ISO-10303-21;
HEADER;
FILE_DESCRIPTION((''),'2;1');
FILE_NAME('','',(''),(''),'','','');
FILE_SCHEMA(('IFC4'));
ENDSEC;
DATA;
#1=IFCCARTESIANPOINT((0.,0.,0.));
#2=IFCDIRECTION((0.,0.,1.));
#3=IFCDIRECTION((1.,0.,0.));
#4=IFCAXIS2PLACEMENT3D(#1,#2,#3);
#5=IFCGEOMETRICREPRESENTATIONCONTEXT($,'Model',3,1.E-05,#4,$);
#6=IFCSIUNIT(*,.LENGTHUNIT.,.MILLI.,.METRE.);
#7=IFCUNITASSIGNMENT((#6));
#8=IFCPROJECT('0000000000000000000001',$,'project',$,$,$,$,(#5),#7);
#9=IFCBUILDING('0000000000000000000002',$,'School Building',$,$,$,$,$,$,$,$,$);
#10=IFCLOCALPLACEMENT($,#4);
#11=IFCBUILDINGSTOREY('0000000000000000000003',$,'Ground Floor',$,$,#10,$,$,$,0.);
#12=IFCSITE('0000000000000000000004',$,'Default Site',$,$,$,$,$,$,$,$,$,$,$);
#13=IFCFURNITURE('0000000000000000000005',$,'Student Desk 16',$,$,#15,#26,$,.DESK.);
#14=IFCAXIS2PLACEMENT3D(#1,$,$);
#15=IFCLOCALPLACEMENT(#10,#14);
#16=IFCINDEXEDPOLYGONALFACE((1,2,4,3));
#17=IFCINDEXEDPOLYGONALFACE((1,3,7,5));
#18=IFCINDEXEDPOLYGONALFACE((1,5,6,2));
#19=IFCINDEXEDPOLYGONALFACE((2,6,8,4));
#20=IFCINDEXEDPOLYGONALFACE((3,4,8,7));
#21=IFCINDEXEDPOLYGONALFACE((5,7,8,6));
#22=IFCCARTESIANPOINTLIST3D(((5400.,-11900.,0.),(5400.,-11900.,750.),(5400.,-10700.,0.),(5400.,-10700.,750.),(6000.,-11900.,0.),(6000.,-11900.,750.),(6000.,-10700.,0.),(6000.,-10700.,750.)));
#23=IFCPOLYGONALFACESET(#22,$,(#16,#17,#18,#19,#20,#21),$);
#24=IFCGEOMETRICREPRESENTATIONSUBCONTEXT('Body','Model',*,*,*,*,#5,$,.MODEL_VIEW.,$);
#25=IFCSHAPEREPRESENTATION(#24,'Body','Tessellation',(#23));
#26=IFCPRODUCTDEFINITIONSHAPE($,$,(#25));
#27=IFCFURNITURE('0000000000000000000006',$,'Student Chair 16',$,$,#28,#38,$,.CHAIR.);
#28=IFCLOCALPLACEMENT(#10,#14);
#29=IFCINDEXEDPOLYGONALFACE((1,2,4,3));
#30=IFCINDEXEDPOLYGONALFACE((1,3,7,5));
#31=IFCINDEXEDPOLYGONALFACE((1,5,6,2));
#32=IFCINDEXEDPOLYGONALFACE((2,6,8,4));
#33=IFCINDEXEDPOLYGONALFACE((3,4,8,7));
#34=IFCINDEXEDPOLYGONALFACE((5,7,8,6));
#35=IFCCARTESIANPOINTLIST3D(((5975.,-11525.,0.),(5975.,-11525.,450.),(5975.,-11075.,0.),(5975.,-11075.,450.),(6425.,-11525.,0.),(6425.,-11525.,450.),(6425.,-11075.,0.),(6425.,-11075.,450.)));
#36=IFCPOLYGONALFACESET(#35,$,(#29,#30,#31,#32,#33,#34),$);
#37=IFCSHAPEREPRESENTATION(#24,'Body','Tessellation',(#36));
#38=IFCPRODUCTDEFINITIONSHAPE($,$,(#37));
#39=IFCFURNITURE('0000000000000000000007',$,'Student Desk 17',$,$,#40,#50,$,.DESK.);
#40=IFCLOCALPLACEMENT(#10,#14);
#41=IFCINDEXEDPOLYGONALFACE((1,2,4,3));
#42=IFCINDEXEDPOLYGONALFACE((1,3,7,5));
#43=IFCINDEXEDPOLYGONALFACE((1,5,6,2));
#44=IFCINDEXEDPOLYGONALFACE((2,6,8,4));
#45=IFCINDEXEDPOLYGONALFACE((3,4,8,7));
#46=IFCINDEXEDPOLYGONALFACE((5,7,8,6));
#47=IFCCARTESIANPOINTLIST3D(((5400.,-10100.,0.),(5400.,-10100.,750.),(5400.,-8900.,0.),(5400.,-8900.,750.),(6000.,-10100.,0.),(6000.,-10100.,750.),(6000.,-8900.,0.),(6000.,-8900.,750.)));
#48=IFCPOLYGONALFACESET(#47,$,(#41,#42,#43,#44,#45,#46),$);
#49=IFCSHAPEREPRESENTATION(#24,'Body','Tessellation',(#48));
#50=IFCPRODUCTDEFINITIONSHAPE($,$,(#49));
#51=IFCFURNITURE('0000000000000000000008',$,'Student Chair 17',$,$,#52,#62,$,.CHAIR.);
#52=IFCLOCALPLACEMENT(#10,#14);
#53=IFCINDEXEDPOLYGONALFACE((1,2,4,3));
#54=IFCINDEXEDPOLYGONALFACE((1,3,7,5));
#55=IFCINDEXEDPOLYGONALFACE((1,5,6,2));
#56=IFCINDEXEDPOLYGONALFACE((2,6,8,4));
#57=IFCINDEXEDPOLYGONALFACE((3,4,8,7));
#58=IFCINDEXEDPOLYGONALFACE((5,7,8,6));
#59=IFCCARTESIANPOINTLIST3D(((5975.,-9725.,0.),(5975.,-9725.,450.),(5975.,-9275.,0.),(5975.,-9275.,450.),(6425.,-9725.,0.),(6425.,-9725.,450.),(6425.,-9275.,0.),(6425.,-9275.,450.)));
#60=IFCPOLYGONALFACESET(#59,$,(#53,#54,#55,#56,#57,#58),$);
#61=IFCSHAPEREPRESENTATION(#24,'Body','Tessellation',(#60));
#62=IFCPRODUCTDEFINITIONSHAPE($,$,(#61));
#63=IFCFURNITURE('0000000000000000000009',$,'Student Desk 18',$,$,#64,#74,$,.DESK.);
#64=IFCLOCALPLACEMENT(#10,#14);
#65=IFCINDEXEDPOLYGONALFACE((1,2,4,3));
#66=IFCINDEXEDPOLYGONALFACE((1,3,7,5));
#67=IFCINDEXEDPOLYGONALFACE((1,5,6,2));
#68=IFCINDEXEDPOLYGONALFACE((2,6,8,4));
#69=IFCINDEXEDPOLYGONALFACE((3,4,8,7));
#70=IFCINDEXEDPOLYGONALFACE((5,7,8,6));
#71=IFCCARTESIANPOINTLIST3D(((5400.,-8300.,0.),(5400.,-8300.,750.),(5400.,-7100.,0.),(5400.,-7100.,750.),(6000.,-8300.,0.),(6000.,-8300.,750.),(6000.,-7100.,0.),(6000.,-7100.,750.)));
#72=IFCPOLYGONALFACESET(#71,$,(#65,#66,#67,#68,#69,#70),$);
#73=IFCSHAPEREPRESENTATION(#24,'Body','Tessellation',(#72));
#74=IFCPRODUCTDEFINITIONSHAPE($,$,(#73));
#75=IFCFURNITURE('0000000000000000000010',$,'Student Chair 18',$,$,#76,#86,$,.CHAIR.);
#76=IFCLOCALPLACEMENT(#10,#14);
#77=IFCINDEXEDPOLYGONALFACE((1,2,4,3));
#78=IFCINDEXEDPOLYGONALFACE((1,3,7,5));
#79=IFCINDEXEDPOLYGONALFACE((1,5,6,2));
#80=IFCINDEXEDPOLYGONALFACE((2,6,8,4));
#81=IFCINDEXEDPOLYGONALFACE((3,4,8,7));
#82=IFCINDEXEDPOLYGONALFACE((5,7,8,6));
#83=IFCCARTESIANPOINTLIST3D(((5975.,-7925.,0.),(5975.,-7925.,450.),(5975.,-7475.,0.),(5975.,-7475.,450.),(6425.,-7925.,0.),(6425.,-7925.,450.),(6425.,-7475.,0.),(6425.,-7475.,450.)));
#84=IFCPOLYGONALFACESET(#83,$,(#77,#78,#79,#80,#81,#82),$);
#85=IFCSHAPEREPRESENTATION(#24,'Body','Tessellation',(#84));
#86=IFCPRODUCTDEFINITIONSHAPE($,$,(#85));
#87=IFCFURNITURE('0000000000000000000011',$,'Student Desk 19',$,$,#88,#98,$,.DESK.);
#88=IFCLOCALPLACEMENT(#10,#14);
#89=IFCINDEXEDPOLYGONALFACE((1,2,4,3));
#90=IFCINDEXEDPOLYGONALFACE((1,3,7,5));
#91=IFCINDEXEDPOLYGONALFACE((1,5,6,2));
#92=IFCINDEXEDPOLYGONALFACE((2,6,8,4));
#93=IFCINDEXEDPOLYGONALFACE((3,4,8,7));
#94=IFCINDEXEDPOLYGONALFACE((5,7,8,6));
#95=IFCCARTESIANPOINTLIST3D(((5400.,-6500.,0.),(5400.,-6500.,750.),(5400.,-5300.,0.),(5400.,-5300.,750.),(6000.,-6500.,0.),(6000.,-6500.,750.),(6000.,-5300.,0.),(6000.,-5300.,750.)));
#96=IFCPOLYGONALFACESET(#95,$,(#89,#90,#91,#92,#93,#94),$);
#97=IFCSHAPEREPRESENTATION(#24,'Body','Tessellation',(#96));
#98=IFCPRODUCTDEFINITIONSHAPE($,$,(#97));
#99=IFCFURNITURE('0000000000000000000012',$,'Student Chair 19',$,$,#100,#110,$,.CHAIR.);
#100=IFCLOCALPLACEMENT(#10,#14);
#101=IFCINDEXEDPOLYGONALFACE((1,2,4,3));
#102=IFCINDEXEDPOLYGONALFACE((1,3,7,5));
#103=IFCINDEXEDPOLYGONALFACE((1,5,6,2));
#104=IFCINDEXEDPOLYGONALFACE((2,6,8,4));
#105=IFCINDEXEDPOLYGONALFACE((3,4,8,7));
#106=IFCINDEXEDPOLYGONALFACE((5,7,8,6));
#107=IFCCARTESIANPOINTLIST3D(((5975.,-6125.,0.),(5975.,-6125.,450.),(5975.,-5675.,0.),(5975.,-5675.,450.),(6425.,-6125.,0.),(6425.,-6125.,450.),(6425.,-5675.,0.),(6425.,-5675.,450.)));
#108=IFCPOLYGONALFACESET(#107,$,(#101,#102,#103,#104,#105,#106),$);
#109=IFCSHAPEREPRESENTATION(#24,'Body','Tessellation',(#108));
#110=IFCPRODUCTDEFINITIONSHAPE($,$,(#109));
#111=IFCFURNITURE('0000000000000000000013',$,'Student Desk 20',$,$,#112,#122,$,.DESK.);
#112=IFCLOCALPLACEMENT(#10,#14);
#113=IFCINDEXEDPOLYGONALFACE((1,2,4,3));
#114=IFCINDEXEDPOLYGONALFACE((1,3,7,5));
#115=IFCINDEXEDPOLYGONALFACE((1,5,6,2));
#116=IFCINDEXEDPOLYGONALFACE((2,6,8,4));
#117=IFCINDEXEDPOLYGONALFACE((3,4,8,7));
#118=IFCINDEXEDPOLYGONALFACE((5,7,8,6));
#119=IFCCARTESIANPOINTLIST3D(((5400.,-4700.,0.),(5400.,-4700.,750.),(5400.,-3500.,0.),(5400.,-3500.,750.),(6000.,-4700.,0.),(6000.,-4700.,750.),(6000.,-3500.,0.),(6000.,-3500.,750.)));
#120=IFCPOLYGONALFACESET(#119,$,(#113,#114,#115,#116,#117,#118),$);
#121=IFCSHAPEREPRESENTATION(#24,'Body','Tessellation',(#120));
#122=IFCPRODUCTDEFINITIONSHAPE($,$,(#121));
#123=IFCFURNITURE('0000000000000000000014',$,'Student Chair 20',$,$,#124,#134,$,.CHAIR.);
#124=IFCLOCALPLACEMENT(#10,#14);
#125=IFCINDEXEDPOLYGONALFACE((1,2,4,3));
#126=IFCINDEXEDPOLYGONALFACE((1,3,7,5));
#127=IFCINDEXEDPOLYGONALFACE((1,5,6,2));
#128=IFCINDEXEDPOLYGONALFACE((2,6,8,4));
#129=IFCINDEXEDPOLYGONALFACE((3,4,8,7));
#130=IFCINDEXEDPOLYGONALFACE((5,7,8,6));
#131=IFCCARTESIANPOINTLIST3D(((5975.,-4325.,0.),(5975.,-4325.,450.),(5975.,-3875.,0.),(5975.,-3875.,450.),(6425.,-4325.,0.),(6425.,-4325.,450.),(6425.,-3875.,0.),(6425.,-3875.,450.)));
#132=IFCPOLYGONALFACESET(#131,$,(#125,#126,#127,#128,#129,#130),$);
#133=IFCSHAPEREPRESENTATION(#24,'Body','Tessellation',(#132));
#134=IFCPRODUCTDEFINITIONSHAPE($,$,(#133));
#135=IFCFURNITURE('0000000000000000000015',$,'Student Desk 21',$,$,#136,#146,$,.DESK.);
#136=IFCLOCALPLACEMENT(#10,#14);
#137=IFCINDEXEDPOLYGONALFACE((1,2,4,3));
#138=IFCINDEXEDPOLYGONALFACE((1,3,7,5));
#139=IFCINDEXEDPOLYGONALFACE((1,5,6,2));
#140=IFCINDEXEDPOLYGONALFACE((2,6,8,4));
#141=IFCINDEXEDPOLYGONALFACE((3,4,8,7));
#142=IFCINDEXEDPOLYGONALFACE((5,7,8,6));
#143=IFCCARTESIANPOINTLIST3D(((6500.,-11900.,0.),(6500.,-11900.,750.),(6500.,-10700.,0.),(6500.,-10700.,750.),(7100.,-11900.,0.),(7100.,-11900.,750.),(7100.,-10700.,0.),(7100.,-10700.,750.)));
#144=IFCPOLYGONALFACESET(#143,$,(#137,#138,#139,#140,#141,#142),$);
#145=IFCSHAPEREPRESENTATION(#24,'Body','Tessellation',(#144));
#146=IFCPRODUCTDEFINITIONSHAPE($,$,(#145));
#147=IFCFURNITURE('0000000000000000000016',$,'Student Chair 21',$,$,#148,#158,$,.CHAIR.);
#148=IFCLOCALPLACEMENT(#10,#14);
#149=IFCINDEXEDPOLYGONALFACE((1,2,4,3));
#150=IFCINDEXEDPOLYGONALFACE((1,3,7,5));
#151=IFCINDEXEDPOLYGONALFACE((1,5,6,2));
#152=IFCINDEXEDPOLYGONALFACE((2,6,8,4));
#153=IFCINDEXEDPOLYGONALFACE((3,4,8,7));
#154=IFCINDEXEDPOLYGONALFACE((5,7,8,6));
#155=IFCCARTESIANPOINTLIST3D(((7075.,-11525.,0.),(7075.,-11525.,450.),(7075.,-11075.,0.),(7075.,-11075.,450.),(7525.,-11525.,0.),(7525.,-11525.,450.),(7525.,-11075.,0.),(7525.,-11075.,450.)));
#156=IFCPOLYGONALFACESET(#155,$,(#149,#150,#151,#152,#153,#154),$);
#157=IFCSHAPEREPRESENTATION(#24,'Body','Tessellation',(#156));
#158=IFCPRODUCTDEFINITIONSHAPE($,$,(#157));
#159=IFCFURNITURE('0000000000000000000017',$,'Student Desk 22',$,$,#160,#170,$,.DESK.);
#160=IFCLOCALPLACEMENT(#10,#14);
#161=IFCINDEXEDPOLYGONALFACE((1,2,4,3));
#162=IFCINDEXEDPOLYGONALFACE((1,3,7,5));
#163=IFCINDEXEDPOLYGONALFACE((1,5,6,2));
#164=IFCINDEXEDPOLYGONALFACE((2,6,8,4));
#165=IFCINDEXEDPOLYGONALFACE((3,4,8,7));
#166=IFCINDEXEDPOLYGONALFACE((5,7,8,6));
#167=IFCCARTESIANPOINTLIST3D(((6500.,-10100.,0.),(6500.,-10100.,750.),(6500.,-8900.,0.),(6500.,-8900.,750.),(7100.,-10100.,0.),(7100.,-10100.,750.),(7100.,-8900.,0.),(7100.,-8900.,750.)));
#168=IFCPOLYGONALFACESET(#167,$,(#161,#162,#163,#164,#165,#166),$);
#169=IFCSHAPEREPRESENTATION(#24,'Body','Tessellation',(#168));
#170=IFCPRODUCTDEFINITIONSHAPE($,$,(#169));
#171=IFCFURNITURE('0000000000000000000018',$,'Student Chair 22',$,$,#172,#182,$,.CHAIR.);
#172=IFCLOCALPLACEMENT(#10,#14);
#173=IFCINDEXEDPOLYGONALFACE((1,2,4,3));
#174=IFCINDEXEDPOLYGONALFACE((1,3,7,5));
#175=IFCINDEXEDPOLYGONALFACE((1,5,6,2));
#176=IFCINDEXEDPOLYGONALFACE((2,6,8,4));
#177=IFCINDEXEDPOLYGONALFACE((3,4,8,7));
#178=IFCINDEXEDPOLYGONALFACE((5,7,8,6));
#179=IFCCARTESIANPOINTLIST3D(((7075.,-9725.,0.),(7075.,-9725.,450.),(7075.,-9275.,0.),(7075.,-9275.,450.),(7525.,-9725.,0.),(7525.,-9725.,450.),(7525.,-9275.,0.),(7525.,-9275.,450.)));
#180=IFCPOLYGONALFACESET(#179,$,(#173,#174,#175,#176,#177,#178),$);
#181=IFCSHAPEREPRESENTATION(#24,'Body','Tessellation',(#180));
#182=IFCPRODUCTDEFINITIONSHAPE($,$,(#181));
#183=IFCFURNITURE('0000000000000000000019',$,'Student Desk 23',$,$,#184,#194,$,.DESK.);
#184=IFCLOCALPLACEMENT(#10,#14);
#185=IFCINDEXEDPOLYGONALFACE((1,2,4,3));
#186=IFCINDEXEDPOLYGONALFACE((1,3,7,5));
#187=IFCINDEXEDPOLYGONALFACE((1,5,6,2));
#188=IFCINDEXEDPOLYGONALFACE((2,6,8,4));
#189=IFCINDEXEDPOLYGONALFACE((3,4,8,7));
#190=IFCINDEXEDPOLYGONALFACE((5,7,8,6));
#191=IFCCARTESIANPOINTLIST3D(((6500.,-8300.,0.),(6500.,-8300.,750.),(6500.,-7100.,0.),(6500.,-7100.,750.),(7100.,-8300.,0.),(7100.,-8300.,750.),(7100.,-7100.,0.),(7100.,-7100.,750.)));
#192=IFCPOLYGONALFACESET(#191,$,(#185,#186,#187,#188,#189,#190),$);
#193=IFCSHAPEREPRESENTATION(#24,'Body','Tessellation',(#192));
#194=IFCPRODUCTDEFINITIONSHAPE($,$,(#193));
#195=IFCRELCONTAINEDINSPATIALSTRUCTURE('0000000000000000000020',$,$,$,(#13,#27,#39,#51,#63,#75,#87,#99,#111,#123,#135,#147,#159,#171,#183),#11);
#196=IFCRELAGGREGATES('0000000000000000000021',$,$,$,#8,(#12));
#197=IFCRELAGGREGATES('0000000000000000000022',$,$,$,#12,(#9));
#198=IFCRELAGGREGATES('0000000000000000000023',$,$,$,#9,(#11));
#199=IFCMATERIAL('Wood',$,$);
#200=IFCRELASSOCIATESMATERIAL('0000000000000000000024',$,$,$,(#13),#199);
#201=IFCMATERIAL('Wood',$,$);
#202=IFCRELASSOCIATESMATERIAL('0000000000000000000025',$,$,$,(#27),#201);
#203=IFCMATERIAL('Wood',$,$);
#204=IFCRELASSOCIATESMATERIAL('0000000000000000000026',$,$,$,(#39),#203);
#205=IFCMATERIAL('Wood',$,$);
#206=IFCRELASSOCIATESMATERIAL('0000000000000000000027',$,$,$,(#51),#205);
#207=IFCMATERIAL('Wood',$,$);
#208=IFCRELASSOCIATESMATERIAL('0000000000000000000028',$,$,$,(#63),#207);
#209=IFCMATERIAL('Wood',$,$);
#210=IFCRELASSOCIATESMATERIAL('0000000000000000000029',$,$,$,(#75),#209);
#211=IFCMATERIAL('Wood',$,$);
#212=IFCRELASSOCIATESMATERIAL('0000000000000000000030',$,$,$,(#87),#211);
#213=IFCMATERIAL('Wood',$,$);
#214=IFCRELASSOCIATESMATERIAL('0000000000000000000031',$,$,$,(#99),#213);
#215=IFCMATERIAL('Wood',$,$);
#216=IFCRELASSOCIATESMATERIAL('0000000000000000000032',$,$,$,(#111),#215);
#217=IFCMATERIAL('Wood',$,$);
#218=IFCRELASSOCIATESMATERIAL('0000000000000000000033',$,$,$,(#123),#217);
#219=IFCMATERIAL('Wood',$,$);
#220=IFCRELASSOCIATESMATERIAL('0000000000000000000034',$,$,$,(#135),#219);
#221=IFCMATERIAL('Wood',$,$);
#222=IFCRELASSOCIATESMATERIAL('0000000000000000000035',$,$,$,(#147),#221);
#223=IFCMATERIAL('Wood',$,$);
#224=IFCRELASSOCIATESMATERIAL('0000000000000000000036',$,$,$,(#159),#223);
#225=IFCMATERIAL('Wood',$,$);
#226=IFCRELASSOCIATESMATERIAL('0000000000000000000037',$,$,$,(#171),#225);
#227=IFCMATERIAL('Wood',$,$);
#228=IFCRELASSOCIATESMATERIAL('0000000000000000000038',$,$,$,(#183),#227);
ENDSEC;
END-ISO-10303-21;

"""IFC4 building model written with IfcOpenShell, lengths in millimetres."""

from ifc_helpers import new_model, si_unit, frame, origin_with_axes, origin_2d, place, context, subcontext, project, spatial, rectangle, extrude, material, element, save


model = new_model("IFC4")

# Units and contexts
model_context = context("Model", 3, precision=1e-05, world=origin_with_axes())
body_context = subcontext(model_context, "Body", "Model", "MODEL_VIEW")
ifc_project = project(units=[si_unit("LENGTHUNIT", "METRE", prefix="MILLI")], contexts=[model_context])

# Site, building, storey
site = spatial("IfcSite", under=ifc_project, Name="Default Site")
building = spatial("IfcBuilding", under=site, Name="School Building")
storey_placement = place(None, origin_with_axes())
storey = spatial("IfcBuildingStorey", under=building, at=storey_placement, Name="Ground Floor", Elevation=0.0)

# Furniture
ifc_material_1 = material(Name="Wood")
furniture_1_placement = place(storey_placement, frame((5700.0, -11300.0, 0.0), z_axis=(0.0, 0.0, 1.0), x_axis=(0.0, 1.0, 0.0)))
element("IfcFurniture", 1, at=furniture_1_placement, inside=storey, material=ifc_material_1, Name="Student Desk 16", PredefinedType="DESK", context=body_context, shape_type="SweptSolid", body=[
    extrude(rectangle(XDim=1200.0, YDim=600.0, at=origin_2d()), origin_with_axes(), (0.0, 0.0, 1.0), 750.0),
])
ifc_material_2 = material(Name="Wood")
furniture_2_placement = place(storey_placement, frame((6200.0, -11300.0, 0.0), z_axis=(0.0, 0.0, 1.0), x_axis=(1.0, 0.0, 0.0)))
element("IfcFurniture", 2, at=furniture_2_placement, inside=storey, material=ifc_material_2, Name="Student Chair 16", PredefinedType="CHAIR", context=body_context, shape_type="SweptSolid", body=[
    extrude(rectangle(XDim=450.0, YDim=450.0, at=origin_2d()), origin_with_axes(), (0.0, 0.0, 1.0), 450.0),
])
ifc_material_3 = material(Name="Wood")
furniture_3_placement = place(storey_placement, frame((5700.0, -9500.0, 0.0), z_axis=(0.0, 0.0, 1.0), x_axis=(0.0, 1.0, 0.0)))
element("IfcFurniture", 3, at=furniture_3_placement, inside=storey, material=ifc_material_3, Name="Student Desk 17", PredefinedType="DESK", context=body_context, shape_type="SweptSolid", body=[
    extrude(rectangle(XDim=1200.0, YDim=600.0, at=origin_2d()), origin_with_axes(), (0.0, 0.0, 1.0), 750.0),
])
ifc_material_4 = material(Name="Wood")
furniture_4_placement = place(storey_placement, frame((6200.0, -9500.0, 0.0), z_axis=(0.0, 0.0, 1.0), x_axis=(1.0, 0.0, 0.0)))
element("IfcFurniture", 4, at=furniture_4_placement, inside=storey, material=ifc_material_4, Name="Student Chair 17", PredefinedType="CHAIR", context=body_context, shape_type="SweptSolid", body=[
    extrude(rectangle(XDim=450.0, YDim=450.0, at=origin_2d()), origin_with_axes(), (0.0, 0.0, 1.0), 450.0),
])
ifc_material_5 = material(Name="Wood")
furniture_5_placement = place(storey_placement, frame((5700.0, -7700.0, 0.0), z_axis=(0.0, 0.0, 1.0), x_axis=(0.0, 1.0, 0.0)))
element("IfcFurniture", 5, at=furniture_5_placement, inside=storey, material=ifc_material_5, Name="Student Desk 18", PredefinedType="DESK", context=body_context, shape_type="SweptSolid", body=[
    extrude(rectangle(XDim=1200.0, YDim=600.0, at=origin_2d()), origin_with_axes(), (0.0, 0.0, 1.0), 750.0),
])
ifc_material_6 = material(Name="Wood")
furniture_6_placement = place(storey_placement, frame((6200.0, -7700.0, 0.0), z_axis=(0.0, 0.0, 1.0), x_axis=(1.0, 0.0, 0.0)))
element("IfcFurniture", 6, at=furniture_6_placement, inside=storey, material=ifc_material_6, Name="Student Chair 18", PredefinedType="CHAIR", context=body_context, shape_type="SweptSolid", body=[
    extrude(rectangle(XDim=450.0, YDim=450.0, at=origin_2d()), origin_with_axes(), (0.0, 0.0, 1.0), 450.0),
])
ifc_material_7 = material(Name="Wood")
furniture_7_placement = place(storey_placement, frame((5700.0, -5900.0, 0.0), z_axis=(0.0, 0.0, 1.0), x_axis=(0.0, 1.0, 0.0)))
element("IfcFurniture", 7, at=furniture_7_placement, inside=storey, material=ifc_material_7, Name="Student Desk 19", PredefinedType="DESK", context=body_context, shape_type="SweptSolid", body=[
    extrude(rectangle(XDim=1200.0, YDim=600.0, at=origin_2d()), origin_with_axes(), (0.0, 0.0, 1.0), 750.0),
])
ifc_material_8 = material(Name="Wood")
furniture_8_placement = place(storey_placement, frame((6200.0, -5900.0, 0.0), z_axis=(0.0, 0.0, 1.0), x_axis=(1.0, 0.0, 0.0)))
element("IfcFurniture", 8, at=furniture_8_placement, inside=storey, material=ifc_material_8, Name="Student Chair 19", PredefinedType="CHAIR", context=body_context, shape_type="SweptSolid", body=[
    extrude(rectangle(XDim=450.0, YDim=450.0, at=origin_2d()), origin_with_axes(), (0.0, 0.0, 1.0), 450.0),
])
ifc_material_9 = material(Name="Wood")
furniture_9_placement = place(storey_placement, frame((5700.0, -4100.0, 0.0), z_axis=(0.0, 0.0, 1.0), x_axis=(0.0, 1.0, 0.0)))
element("IfcFurniture", 9, at=furniture_9_placement, inside=storey, material=ifc_material_9, Name="Student Desk 20", PredefinedType="DESK", context=body_context, shape_type="SweptSolid", body=[
    extrude(rectangle(XDim=1200.0, YDim=600.0, at=origin_2d()), origin_with_axes(), (0.0, 0.0, 1.0), 750.0),
])
ifc_material_10 = material(Name="Wood")
furniture_10_placement = place(storey_placement, frame((6200.0, -4100.0, 0.0), z_axis=(0.0, 0.0, 1.0), x_axis=(1.0, 0.0, 0.0)))
element("IfcFurniture", 10, at=furniture_10_placement, inside=storey, material=ifc_material_10, Name="Student Chair 20", PredefinedType="CHAIR", context=body_context, shape_type="SweptSolid", body=[
    extrude(rectangle(XDim=450.0, YDim=450.0, at=origin_2d()), origin_with_axes(), (0.0, 0.0, 1.0), 450.0),
])
ifc_material_11 = material(Name="Wood")
furniture_11_placement = place(storey_placement, frame((6800.0, -11300.0, 0.0), z_axis=(0.0, 0.0, 1.0), x_axis=(0.0, 1.0, 0.0)))
element("IfcFurniture", 11, at=furniture_11_placement, inside=storey, material=ifc_material_11, Name="Student Desk 21", PredefinedType="DESK", context=body_context, shape_type="SweptSolid", body=[
    extrude(rectangle(XDim=1200.0, YDim=600.0, at=origin_2d()), origin_with_axes(), (0.0, 0.0, 1.0), 750.0),
])
ifc_material_12 = material(Name="Wood")
furniture_12_placement = place(storey_placement, frame((7300.0, -11300.0, 0.0), z_axis=(0.0, 0.0, 1.0), x_axis=(1.0, 0.0, 0.0)))
element("IfcFurniture", 12, at=furniture_12_placement, inside=storey, material=ifc_material_12, Name="Student Chair 21", PredefinedType="CHAIR", context=body_context, shape_type="SweptSolid", body=[
    extrude(rectangle(XDim=450.0, YDim=450.0, at=origin_2d()), origin_with_axes(), (0.0, 0.0, 1.0), 450.0),
])
ifc_material_13 = material(Name="Wood")
furniture_13_placement = place(storey_placement, frame((6800.0, -9500.0, 0.0), z_axis=(0.0, 0.0, 1.0), x_axis=(0.0, 1.0, 0.0)))
element("IfcFurniture", 13, at=furniture_13_placement, inside=storey, material=ifc_material_13, Name="Student Desk 22", PredefinedType="DESK", context=body_context, shape_type="SweptSolid", body=[
    extrude(rectangle(XDim=1200.0, YDim=600.0, at=origin_2d()), origin_with_axes(), (0.0, 0.0, 1.0), 750.0),
])
ifc_material_14 = material(Name="Wood")
furniture_14_placement = place(storey_placement, frame((7300.0, -9500.0, 0.0), z_axis=(0.0, 0.0, 1.0), x_axis=(1.0, 0.0, 0.0)))
element("IfcFurniture", 14, at=furniture_14_placement, inside=storey, material=ifc_material_14, Name="Student Chair 22", PredefinedType="CHAIR", context=body_context, shape_type="SweptSolid", body=[
    extrude(rectangle(XDim=450.0, YDim=450.0, at=origin_2d()), origin_with_axes(), (0.0, 0.0, 1.0), 450.0),
])
ifc_material_15 = material(Name="Wood")
furniture_15_placement = place(storey_placement, frame((6800.0, -7700.0, 0.0), z_axis=(0.0, 0.0, 1.0), x_axis=(0.0, 1.0, 0.0)))
element("IfcFurniture", 15, at=furniture_15_placement, inside=storey, material=ifc_material_15, Name="Student Desk 23", PredefinedType="DESK", context=body_context, shape_type="SweptSolid", body=[
    extrude(rectangle(XDim=1200.0, YDim=600.0, at=origin_2d()), origin_with_axes(), (0.0, 0.0, 1.0), 750.0),
])

save(model, "model.ifc")
